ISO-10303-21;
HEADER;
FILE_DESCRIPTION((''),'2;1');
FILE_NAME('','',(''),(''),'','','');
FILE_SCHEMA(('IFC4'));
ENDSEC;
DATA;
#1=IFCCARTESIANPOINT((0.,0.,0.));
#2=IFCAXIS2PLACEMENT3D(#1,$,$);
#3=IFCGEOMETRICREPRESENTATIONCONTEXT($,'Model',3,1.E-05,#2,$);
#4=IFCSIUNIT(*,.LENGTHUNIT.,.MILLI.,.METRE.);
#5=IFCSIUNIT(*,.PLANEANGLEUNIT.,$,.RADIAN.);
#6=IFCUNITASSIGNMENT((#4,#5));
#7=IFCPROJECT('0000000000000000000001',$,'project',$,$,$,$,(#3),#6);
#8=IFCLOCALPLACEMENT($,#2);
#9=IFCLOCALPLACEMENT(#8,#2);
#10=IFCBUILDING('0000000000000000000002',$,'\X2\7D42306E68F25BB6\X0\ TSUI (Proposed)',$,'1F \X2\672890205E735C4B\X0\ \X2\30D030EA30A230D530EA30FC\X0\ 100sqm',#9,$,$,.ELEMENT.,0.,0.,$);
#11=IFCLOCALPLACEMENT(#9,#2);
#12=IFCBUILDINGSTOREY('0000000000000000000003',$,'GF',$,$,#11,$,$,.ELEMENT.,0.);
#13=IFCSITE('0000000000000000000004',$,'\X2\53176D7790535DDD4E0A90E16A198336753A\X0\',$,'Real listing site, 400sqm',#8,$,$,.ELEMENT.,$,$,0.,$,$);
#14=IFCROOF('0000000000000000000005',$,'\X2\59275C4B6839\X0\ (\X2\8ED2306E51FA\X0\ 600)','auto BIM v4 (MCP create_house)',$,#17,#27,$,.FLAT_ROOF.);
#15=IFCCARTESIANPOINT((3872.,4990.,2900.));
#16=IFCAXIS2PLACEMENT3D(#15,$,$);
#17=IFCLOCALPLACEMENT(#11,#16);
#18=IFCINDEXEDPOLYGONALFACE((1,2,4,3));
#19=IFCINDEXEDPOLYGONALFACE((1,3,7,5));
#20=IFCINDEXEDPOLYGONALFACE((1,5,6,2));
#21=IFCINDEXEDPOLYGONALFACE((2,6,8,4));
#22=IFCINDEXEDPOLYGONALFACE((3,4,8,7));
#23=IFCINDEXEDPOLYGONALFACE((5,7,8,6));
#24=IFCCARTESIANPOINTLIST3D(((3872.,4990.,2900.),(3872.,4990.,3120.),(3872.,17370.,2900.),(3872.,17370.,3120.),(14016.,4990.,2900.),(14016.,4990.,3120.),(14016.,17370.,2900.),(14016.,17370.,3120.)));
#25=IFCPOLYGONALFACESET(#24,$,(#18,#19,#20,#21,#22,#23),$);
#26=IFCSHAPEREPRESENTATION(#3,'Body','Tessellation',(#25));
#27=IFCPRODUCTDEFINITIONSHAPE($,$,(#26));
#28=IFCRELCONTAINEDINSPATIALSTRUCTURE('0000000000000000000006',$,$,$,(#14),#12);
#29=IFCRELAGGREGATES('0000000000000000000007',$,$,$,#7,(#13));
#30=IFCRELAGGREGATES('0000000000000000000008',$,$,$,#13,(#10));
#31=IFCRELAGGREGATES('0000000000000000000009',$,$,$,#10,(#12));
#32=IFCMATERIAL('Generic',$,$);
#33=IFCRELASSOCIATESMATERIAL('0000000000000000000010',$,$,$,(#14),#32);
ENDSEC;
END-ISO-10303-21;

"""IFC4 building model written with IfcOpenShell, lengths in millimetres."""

from ifc_helpers import new_model, si_unit, frame, frame_2d, origin, place, context, project, spatial, rectangle, extrude, material, element, save


model = new_model("IFC4")

# Units and contexts
model_context = context("Model", 3, precision=1e-05, world=origin())
ifc_project = project(units=[si_unit("LENGTHUNIT", "METRE", prefix="MILLI"), si_unit("PLANEANGLEUNIT", "RADIAN")], contexts=[model_context])

# Site, building, storey
site_placement = place(None, origin())
site = spatial("IfcSite", under=ifc_project, at=site_placement, Name="北海道川上郡標茶町", ObjectType="Real listing site, 400sqm", CompositionType="ELEMENT", RefElevation=0.0)
building_placement = place(site_placement, origin())
building = spatial("IfcBuilding", under=site, at=building_placement, Name="終の棲家 TSUI (Proposed)", ObjectType="1F 木造平屋 バリアフリー 100sqm", CompositionType="ELEMENT", ElevationOfRefHeight=0.0, ElevationOfTerrain=0.0)
storey_placement = place(building_placement, origin())
storey = spatial("IfcBuildingStorey", under=building, at=storey_placement, Name="GF", CompositionType="ELEMENT", Elevation=0.0)

# Shared definitions
ifc_material = material(Name="Generic")

# Roof
roof_placement = place(storey_placement, frame((3872.0, 4990.0, 2900.0)))
element("IfcRoof", 1, at=roof_placement, inside=storey, material=ifc_material, Name="大屋根 (軒の出 600)", Description="auto BIM v4 (MCP create_house)", PredefinedType="FLAT_ROOF", context=model_context, shape_type="SweptSolid", body=[
    extrude(rectangle(XDim=10144.0, YDim=12380.0, at=frame_2d((5072.0, 6190.0))), frame((3872.0, 4990.0, 2900.0)), (0.0, 0.0, 1.0), 220.0),
])

save(model, "model.ifc")
